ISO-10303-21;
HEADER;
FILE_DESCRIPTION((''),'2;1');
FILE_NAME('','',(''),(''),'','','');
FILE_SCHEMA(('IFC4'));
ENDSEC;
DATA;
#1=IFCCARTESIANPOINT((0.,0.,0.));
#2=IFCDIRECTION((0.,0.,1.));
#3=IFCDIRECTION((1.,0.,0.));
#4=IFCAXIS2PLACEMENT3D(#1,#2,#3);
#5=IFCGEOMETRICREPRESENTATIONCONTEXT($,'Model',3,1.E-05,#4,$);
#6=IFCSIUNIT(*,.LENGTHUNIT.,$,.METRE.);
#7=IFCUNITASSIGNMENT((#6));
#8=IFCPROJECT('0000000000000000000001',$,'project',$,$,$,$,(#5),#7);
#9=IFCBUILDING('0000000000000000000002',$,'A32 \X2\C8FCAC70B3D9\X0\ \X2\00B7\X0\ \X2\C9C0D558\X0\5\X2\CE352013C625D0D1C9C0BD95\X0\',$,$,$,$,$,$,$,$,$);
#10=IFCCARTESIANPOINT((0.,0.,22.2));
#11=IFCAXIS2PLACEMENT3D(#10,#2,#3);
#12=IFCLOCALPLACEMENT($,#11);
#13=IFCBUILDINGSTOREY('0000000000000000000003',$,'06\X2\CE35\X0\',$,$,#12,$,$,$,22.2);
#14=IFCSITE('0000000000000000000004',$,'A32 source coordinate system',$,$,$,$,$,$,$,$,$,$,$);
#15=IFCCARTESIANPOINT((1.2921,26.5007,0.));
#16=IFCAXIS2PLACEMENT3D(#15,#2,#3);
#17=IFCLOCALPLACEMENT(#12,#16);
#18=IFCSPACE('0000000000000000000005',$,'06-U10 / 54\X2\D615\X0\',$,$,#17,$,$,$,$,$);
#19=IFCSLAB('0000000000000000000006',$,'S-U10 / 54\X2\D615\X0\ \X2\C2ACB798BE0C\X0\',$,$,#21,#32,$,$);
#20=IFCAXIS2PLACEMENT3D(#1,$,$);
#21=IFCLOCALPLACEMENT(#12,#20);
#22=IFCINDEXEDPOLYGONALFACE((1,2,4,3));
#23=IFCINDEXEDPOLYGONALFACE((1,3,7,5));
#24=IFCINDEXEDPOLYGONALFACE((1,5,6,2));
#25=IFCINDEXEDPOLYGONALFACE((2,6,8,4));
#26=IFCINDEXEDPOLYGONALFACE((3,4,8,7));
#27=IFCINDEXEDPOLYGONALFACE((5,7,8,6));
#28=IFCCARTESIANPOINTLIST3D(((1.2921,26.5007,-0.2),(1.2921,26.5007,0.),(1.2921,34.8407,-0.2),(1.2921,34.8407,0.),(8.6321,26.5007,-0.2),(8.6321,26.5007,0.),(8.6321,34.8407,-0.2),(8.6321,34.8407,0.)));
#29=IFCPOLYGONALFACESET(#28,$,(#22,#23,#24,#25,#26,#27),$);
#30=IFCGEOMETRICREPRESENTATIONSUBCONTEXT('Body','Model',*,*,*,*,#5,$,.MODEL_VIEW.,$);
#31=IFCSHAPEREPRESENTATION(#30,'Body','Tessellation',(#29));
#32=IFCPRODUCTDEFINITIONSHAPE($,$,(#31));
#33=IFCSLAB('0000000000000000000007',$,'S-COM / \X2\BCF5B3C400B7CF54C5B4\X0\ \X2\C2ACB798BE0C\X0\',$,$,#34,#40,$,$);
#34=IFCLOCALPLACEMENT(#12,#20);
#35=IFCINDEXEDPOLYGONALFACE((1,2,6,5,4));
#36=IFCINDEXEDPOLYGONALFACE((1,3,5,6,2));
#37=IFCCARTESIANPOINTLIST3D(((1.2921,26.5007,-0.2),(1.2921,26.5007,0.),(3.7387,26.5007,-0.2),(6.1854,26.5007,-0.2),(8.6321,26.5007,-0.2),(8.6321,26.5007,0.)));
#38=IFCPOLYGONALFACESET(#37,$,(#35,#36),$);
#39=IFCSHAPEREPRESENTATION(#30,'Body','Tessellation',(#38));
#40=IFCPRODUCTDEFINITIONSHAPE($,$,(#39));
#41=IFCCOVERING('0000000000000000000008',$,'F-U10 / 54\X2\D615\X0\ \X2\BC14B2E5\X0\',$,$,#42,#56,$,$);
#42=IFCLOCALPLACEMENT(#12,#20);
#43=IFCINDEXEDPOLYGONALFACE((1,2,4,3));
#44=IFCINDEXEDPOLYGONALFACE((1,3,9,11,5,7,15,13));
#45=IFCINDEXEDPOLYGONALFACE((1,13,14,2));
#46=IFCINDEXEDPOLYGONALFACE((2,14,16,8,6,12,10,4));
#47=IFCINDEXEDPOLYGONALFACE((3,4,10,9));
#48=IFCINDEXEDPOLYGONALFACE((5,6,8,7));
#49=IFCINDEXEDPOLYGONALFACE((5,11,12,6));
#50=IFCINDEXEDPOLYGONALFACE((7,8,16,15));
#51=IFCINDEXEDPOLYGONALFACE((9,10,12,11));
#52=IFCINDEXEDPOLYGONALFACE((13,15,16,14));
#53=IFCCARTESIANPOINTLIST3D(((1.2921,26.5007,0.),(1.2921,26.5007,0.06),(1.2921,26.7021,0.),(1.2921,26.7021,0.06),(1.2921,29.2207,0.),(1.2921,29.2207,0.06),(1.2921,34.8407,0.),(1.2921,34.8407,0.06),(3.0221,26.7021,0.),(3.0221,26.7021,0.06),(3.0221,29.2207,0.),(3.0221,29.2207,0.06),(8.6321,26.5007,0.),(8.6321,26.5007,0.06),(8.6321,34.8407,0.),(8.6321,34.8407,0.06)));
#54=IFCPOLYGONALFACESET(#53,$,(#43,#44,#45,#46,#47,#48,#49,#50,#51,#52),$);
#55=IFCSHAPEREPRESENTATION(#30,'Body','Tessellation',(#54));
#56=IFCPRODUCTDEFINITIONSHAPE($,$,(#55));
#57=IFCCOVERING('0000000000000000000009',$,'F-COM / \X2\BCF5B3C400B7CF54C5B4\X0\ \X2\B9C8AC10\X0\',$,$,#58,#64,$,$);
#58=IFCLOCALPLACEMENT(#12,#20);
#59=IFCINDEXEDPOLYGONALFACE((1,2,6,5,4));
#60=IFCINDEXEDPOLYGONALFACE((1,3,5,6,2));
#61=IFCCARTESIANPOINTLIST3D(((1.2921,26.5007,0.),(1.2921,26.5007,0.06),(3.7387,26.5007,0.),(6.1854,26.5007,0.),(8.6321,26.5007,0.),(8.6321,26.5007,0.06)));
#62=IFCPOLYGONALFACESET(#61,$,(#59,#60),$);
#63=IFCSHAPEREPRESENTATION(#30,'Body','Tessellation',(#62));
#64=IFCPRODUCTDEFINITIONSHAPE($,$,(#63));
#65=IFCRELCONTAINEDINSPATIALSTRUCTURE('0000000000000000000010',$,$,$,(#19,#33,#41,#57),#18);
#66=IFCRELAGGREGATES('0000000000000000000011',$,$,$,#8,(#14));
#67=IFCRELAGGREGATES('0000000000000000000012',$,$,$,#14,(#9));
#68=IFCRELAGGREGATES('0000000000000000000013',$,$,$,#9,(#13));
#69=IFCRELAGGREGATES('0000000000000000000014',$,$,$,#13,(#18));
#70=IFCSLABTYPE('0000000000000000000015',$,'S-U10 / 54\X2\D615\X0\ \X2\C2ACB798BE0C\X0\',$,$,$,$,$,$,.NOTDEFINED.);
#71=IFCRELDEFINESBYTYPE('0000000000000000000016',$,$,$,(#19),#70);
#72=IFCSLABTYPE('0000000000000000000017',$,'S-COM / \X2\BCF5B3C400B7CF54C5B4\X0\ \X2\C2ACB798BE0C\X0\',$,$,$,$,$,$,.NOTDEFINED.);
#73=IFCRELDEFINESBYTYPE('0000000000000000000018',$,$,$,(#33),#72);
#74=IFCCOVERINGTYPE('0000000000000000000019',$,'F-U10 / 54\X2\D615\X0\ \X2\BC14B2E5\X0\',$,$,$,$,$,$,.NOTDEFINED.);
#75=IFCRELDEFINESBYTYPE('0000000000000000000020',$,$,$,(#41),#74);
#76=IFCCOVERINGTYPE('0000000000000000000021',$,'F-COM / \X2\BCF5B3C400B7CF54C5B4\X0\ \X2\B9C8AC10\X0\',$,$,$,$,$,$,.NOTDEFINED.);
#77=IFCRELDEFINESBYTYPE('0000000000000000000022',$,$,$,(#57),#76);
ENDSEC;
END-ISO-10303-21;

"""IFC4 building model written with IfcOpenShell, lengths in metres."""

from ifc_helpers import new_model, si_unit, frame, origin, origin_with_axes, place, context, subcontext, project, spatial, polyline, outline, extrude, source, transform, mapped, type_object, type_shapes, element, save


model = new_model("IFC4")

# Units and contexts
model_context = context("Model", 3, precision=1e-05, world=origin_with_axes())
body_context = subcontext(model_context, "Body", "Model", "MODEL_VIEW")
ifc_project = project(units=[si_unit("LENGTHUNIT", "METRE")], contexts=[model_context])

# Site, building, storey, space
storey_placement = place(None, frame((0.0, 0.0, 22.2), z_axis=(0.0, 0.0, 1.0), x_axis=(1.0, 0.0, 0.0)))
space_placement = place(storey_placement, frame((1.2921, 26.5007, 0.0), z_axis=(0.0, 0.0, 1.0), x_axis=(1.0, 0.0, 0.0)))
site = spatial("IfcSite", under=ifc_project, Name="A32 source coordinate system")
building = spatial("IfcBuilding", under=site, Name="A32 주거동 · 지하5층–옥탑지붕")
storey = spatial("IfcBuildingStorey", under=building, at=storey_placement, Name="06층", Elevation=22.2)
space = spatial("IfcSpace", under=storey, at=space_placement, Name="06-U10 / 54형")

# Slabs
slab_type_1 = type_object("IfcSlabType", Name="S-U10 / 54형 슬래브", PredefinedType="NOTDEFINED")
shared_shape_1 = source(origin(), body_context, "Body", "SweptSolid", [
    extrude(outline(polyline([(0.0, 0.0), (0.0, 8.34), (7.34, 8.34), (7.34, 0.0), (0.0, 0.0)])), frame((0.0, 0.0, -0.2)), (0.0, 0.0, 1.0), 0.2),
])
type_shapes(slab_type_1, [shared_shape_1])
slab_1_placement = place(space_placement, origin_with_axes())
element("IfcSlab", 1, at=slab_1_placement, inside=space, type_object=slab_type_1, Name="S-U10 / 54형 슬래브", context=body_context, shape_type="MappedRepresentation", body=[
    mapped(shared_shape_1, transform((0.0, 0.0, 0.0), scale=1.0)),
])
slab_type_2 = type_object("IfcSlabType", Name="S-COM / 복도·코어 슬래브", PredefinedType="NOTDEFINED")
shared_shape_2 = source(origin(), body_context, "Body", "SweptSolid", [
    extrude(outline(polyline([(7.34, 0.0), (7.34, 0.0), (0.0, 0.0), (0.0, 0.0), (7.34, 0.0)])), frame((0.0, 0.0, -0.2)), (0.0, 0.0, 1.0), 0.2),
])
type_shapes(slab_type_2, [shared_shape_2])
slab_2_placement = place(space_placement, origin_with_axes())
element("IfcSlab", 2, at=slab_2_placement, inside=space, type_object=slab_type_2, Name="S-COM / 복도·코어 슬래브", context=body_context, shape_type="MappedRepresentation", body=[
    mapped(shared_shape_2, transform((0.0, 0.0, 0.0), scale=1.0)),
])

# Coverings
covering_type_1 = type_object("IfcCoveringType", Name="F-U10 / 54형 바닥", PredefinedType="NOTDEFINED")
shared_shape_3 = source(origin(), body_context, "Body", "SweptSolid", [
    extrude(outline(polyline([(7.34, 0.0), (0.0, 0.0), (0.0, 0.2014), (1.73, 0.2014), (1.73, 2.72), (0.0, 2.72), (0.0, 8.34), (7.34, 8.34), (7.34, 0.0)])), origin(), (0.0, 0.0, 1.0), 0.06),
])
type_shapes(covering_type_1, [shared_shape_3])
covering_1_placement = place(space_placement, origin_with_axes())
element("IfcCovering", 3, at=covering_1_placement, inside=space, type_object=covering_type_1, Name="F-U10 / 54형 바닥", context=body_context, shape_type="MappedRepresentation", body=[
    mapped(shared_shape_3, transform((0.0, 0.0, 0.0), scale=1.0)),
])
covering_type_2 = type_object("IfcCoveringType", Name="F-COM / 복도·코어 마감", PredefinedType="NOTDEFINED")
shared_shape_4 = source(origin(), body_context, "Body", "SweptSolid", [
    extrude(outline(polyline([(7.34, 0.0), (7.34, 0.0), (0.0, 0.0), (0.0, 0.0), (7.34, 0.0)])), origin(), (0.0, 0.0, 1.0), 0.06),
])
type_shapes(covering_type_2, [shared_shape_4])
covering_2_placement = place(space_placement, origin_with_axes())
element("IfcCovering", 4, at=covering_2_placement, inside=space, type_object=covering_type_2, Name="F-COM / 복도·코어 마감", context=body_context, shape_type="MappedRepresentation", body=[
    mapped(shared_shape_4, transform((0.0, 0.0, 0.0), scale=1.0)),
])

save(model, "model.ifc")
